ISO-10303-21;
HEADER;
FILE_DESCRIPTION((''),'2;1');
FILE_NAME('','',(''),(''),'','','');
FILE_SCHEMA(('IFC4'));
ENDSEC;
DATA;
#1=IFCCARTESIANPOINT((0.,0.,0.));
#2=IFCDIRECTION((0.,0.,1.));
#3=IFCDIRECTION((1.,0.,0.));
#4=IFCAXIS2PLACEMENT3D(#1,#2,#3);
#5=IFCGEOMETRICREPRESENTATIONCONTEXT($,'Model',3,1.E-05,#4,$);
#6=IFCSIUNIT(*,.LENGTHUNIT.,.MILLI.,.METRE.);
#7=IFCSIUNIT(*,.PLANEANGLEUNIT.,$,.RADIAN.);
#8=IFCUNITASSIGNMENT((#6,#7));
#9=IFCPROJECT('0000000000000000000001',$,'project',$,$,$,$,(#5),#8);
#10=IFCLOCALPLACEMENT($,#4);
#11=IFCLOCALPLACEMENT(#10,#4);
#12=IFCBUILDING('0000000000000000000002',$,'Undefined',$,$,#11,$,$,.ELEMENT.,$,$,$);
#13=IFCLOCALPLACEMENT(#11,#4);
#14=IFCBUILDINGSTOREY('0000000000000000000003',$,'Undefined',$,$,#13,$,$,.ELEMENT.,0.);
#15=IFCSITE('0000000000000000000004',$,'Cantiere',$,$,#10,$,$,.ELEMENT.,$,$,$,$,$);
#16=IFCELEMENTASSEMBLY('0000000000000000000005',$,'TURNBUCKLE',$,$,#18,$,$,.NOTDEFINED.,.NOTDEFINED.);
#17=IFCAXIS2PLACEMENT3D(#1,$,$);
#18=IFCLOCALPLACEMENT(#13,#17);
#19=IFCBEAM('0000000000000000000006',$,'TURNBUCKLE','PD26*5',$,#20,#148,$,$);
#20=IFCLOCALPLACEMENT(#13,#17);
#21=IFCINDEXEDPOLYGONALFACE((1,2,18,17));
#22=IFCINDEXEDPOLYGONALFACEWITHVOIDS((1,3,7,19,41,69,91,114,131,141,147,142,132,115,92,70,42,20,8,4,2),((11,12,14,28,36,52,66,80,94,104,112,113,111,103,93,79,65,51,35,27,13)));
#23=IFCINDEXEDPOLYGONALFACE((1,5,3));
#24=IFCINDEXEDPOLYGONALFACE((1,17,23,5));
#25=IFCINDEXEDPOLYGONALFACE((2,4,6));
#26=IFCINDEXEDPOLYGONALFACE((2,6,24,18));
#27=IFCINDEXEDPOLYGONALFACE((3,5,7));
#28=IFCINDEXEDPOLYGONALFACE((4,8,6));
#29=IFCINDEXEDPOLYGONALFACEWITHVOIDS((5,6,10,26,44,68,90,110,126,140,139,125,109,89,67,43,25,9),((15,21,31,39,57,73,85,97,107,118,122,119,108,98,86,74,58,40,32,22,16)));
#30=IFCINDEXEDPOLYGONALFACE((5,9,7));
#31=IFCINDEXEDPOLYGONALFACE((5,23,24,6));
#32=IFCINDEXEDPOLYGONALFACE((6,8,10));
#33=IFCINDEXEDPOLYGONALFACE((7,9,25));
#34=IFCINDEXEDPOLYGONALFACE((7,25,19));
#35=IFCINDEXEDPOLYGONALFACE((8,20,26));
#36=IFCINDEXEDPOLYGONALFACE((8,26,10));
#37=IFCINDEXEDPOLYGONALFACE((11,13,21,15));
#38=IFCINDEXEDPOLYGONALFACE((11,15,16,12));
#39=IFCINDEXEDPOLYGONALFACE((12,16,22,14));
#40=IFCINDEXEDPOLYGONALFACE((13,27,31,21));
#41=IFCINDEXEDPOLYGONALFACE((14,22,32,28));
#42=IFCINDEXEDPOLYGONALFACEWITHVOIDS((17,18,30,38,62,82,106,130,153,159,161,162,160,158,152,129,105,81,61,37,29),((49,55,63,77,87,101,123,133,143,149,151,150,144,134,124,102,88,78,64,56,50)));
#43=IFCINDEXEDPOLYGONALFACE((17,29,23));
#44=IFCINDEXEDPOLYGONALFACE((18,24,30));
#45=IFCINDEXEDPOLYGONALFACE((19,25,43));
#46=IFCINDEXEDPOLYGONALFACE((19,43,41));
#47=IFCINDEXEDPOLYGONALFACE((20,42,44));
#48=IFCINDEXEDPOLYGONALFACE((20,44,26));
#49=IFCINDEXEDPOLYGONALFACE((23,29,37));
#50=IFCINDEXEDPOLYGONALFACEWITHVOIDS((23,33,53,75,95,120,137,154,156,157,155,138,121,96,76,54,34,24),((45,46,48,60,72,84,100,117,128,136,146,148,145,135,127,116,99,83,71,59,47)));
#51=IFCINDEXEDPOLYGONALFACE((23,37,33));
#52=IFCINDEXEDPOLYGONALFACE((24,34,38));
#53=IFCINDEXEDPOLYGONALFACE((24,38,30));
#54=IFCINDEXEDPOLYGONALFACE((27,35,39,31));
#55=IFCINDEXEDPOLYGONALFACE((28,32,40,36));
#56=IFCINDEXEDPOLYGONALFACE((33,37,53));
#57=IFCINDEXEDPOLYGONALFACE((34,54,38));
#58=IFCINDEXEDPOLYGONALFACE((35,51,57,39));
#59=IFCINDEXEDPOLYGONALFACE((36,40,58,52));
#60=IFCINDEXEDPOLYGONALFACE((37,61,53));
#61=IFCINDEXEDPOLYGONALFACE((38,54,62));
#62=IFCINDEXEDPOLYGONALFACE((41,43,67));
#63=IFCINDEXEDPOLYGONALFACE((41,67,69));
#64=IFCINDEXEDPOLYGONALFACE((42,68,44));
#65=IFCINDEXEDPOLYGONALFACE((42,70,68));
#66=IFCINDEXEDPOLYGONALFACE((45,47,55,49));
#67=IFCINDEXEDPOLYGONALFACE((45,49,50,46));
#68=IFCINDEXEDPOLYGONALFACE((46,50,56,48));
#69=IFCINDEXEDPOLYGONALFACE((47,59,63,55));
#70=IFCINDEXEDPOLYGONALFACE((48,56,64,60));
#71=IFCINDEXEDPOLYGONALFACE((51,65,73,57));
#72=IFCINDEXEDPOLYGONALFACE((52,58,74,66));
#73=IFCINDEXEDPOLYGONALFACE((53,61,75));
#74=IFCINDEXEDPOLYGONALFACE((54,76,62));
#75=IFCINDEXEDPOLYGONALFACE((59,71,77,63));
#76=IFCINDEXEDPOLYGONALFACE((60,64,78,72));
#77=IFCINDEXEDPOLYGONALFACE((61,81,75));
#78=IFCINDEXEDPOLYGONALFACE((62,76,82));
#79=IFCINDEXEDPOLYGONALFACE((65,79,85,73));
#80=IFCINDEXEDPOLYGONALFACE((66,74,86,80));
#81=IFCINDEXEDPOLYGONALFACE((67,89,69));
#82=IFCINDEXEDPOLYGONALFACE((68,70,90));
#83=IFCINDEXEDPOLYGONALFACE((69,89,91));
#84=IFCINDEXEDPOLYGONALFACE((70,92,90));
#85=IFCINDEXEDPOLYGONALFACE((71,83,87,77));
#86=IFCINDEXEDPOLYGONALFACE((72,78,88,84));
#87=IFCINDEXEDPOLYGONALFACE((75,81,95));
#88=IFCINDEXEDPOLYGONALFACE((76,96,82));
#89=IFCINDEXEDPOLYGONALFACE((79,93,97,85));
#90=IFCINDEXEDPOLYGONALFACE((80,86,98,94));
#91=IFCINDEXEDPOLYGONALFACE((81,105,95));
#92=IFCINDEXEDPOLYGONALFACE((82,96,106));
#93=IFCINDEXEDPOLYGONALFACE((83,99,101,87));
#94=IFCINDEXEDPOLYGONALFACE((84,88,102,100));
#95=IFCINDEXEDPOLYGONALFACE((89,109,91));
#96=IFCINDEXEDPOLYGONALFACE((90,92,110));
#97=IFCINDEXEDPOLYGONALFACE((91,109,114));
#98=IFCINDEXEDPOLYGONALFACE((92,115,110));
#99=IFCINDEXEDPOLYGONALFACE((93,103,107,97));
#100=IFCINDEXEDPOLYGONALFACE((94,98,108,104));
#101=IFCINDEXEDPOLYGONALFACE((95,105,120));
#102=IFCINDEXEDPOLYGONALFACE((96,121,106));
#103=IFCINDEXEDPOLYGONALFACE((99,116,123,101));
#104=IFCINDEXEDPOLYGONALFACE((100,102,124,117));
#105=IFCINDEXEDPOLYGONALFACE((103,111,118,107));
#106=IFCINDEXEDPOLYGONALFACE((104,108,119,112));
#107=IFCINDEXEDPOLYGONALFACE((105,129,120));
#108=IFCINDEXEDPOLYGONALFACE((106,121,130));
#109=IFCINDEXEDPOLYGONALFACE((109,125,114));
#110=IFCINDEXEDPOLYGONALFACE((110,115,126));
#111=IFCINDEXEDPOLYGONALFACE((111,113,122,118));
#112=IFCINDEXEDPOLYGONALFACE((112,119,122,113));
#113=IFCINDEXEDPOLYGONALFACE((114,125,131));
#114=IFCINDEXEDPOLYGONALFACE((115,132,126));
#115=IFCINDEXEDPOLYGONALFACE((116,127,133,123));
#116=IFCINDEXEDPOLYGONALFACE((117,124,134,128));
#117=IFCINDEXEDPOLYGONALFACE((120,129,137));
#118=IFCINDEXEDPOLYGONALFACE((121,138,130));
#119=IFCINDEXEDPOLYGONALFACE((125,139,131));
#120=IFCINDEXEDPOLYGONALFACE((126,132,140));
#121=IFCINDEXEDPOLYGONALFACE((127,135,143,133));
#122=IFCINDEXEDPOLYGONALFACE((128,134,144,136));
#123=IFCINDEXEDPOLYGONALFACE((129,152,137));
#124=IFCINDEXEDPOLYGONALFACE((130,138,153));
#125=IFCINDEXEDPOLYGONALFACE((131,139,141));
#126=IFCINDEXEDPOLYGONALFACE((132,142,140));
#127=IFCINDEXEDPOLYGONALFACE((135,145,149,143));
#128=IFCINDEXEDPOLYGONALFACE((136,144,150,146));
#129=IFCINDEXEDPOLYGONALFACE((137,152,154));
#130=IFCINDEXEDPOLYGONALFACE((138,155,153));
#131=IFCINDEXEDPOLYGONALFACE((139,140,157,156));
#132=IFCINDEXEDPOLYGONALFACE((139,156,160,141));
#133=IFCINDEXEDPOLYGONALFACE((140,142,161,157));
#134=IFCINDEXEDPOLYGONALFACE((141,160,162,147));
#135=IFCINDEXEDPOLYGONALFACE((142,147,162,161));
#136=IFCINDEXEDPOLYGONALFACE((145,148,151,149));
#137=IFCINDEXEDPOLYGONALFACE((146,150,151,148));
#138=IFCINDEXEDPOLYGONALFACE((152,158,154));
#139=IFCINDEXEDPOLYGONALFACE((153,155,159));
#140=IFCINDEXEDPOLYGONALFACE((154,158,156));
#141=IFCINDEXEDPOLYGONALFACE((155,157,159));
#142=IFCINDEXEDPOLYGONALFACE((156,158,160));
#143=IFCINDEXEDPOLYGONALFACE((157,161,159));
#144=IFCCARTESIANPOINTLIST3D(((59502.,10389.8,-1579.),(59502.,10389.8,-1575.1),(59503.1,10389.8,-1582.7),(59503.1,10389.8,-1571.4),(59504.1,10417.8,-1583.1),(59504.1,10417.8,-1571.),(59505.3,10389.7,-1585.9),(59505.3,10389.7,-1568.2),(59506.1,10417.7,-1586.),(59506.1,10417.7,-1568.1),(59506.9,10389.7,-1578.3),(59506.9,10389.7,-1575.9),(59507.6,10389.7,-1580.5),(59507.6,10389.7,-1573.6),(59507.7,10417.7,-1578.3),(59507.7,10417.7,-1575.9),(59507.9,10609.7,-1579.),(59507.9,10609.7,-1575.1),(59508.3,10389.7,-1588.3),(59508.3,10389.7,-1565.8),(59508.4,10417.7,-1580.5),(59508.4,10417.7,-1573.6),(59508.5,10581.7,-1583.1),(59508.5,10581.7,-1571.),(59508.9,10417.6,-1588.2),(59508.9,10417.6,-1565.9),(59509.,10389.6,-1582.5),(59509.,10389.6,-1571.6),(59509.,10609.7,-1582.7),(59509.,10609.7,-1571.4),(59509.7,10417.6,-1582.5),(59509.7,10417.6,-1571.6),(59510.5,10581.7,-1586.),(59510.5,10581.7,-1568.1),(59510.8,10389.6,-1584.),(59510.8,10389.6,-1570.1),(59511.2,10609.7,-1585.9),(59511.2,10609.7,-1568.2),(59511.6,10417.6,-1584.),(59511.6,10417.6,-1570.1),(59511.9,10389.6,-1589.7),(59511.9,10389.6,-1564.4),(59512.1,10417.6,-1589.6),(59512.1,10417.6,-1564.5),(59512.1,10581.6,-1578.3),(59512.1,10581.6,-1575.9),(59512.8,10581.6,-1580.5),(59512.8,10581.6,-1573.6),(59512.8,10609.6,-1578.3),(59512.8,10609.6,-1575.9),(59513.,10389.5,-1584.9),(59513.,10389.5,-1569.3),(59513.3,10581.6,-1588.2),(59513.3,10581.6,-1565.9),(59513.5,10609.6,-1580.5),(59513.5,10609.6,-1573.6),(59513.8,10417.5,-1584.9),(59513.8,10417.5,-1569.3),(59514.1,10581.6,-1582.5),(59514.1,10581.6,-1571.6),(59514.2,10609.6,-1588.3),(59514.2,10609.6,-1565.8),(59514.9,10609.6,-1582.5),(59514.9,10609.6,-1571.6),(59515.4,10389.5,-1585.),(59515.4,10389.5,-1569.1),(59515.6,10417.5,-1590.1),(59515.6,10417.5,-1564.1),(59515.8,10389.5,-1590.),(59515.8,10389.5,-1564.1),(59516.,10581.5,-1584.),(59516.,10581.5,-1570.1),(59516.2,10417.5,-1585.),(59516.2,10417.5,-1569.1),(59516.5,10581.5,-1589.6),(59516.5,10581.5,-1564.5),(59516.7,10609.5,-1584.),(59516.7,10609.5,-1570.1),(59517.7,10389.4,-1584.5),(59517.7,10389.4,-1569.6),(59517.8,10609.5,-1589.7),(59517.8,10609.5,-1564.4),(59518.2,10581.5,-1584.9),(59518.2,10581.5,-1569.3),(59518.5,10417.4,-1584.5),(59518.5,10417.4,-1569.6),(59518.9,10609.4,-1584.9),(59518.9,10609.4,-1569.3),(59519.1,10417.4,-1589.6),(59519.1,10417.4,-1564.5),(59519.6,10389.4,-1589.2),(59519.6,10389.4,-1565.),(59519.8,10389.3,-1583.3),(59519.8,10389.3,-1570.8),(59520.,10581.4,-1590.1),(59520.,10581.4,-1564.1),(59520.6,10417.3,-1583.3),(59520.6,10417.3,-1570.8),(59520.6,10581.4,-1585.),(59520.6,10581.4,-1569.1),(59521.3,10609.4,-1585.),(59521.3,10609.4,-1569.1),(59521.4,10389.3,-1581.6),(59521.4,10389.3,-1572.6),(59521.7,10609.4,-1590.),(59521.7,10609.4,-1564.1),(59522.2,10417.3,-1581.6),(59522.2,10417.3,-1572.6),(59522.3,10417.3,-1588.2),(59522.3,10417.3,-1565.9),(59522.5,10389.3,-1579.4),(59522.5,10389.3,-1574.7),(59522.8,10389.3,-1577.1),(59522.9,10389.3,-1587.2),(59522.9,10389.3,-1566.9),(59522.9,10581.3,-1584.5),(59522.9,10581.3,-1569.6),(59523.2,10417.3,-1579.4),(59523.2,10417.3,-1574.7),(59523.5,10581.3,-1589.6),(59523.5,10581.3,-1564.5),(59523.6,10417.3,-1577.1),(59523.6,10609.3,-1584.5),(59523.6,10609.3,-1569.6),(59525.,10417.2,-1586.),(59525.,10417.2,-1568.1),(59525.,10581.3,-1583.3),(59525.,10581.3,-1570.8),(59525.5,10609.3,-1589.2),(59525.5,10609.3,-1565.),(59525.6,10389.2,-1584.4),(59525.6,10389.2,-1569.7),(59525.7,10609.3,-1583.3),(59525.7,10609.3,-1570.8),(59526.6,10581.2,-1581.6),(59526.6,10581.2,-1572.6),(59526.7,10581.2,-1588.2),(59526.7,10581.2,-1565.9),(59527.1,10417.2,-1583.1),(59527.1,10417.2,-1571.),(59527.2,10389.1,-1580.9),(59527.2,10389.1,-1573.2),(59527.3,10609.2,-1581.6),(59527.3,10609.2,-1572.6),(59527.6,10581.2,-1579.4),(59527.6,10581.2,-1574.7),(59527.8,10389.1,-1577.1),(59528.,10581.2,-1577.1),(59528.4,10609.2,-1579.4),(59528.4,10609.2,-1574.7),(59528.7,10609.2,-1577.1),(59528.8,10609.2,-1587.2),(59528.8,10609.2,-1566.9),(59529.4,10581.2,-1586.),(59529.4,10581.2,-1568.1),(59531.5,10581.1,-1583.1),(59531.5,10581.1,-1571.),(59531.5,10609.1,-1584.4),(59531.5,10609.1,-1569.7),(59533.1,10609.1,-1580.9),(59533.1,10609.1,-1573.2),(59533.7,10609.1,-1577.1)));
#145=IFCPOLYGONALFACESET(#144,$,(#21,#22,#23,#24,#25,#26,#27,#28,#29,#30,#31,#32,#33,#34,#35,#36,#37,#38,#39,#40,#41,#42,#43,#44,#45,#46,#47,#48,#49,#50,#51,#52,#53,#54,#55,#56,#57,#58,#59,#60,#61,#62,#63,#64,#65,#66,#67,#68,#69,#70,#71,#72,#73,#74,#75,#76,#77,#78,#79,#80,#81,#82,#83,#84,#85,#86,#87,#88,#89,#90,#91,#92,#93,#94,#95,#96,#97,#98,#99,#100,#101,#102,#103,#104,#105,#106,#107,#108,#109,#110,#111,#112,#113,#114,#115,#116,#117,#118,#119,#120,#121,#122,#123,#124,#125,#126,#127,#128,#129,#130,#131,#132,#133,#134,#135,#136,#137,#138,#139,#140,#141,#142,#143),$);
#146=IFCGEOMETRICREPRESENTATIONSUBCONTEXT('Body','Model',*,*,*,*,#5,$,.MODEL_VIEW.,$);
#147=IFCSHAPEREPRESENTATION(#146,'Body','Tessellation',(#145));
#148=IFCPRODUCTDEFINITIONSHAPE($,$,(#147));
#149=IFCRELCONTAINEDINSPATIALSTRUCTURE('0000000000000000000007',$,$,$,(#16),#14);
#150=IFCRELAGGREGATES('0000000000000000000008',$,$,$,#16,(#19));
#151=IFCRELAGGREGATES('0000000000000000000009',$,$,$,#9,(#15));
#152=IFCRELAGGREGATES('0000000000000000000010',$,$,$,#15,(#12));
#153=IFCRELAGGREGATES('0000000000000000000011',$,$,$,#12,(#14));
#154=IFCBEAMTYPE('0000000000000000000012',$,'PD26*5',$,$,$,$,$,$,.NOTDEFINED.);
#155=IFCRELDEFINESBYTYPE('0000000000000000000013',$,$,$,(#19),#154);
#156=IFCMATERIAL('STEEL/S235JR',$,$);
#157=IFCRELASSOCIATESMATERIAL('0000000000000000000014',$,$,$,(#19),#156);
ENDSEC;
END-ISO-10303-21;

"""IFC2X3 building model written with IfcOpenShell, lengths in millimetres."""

from ifc_helpers import new_model, si_unit, frame, origin_with_axes, origin_2d_with_axis, place, context, subcontext, project, spatial, rectangle, hollow_circle, extrude, boolean, material, type_object, element, aggregate, save


model = new_model("IFC2X3")

# Units and contexts
model_context = context("Model", 3, precision=1e-05, world=origin_with_axes())
body_context = subcontext(model_context, "Body", "Model", "MODEL_VIEW")
ifc_project = project(units=[si_unit("LENGTHUNIT", "METRE", prefix="MILLI"), si_unit("PLANEANGLEUNIT", "RADIAN")], contexts=[model_context])

# Site, building, storey
site_placement = place(None, origin_with_axes())
site = spatial("IfcSite", under=ifc_project, at=site_placement, Name="Cantiere", CompositionType="ELEMENT")
building_placement = place(site_placement, origin_with_axes())
building = spatial("IfcBuilding", under=site, at=building_placement, Name="Undefined", CompositionType="ELEMENT")
storey_placement = place(building_placement, origin_with_axes())
storey = spatial("IfcBuildingStorey", under=building, at=storey_placement, Name="Undefined", CompositionType="ELEMENT", Elevation=0.0)

# Shared definitions
ifc_material_1 = material(Name="STEEL/S235JR")

# Element assembly, beam
assembly_1_placement = place(storey_placement, origin_with_axes())
assembly_1 = element("IfcElementAssembly", 1, at=assembly_1_placement, inside=storey, Name="TURNBUCKLE", AssemblyPlace="NOTDEFINED", PredefinedType="NOTDEFINED")
beam_type = type_object("IfcBeamType", Name="PD26*5", PredefinedType="NOTDEFINED")
beam_placement = place(assembly_1_placement, frame((59520.7, 10609.4, -1577.1), z_axis=(0.0, 0.000001, -1.0), x_axis=(-0.02679, -0.999641, 0.0)))
beam = element("IfcBeam", 2, at=beam_placement, type_object=beam_type, material=ifc_material_1, Name="TURNBUCKLE", Description="PD26*5", context=body_context, shape_type="CSG", body=[
    boolean("DIFFERENCE", extrude(hollow_circle(Radius=13.0, WallThickness=5.0, at=origin_2d_with_axis()), frame((220.0, 0.0, 0.0), z_axis=(-1.0, 0.0, 0.0), x_axis=(0.0, -1.0, 0.0)), (0.0, 0.0, 1.0), 220.0), extrude(rectangle(XDim=23.0, YDim=68.0, at=origin_2d_with_axis()), frame((192.0, 0.0, 0.0), z_axis=(-1.0, 0.0, 0.0), x_axis=(0.0, -1.0, 0.0)), (0.0, 0.0, 1.0), 164.0)),
])
aggregate(assembly_1, [beam])

save(model, "model.ifc")
